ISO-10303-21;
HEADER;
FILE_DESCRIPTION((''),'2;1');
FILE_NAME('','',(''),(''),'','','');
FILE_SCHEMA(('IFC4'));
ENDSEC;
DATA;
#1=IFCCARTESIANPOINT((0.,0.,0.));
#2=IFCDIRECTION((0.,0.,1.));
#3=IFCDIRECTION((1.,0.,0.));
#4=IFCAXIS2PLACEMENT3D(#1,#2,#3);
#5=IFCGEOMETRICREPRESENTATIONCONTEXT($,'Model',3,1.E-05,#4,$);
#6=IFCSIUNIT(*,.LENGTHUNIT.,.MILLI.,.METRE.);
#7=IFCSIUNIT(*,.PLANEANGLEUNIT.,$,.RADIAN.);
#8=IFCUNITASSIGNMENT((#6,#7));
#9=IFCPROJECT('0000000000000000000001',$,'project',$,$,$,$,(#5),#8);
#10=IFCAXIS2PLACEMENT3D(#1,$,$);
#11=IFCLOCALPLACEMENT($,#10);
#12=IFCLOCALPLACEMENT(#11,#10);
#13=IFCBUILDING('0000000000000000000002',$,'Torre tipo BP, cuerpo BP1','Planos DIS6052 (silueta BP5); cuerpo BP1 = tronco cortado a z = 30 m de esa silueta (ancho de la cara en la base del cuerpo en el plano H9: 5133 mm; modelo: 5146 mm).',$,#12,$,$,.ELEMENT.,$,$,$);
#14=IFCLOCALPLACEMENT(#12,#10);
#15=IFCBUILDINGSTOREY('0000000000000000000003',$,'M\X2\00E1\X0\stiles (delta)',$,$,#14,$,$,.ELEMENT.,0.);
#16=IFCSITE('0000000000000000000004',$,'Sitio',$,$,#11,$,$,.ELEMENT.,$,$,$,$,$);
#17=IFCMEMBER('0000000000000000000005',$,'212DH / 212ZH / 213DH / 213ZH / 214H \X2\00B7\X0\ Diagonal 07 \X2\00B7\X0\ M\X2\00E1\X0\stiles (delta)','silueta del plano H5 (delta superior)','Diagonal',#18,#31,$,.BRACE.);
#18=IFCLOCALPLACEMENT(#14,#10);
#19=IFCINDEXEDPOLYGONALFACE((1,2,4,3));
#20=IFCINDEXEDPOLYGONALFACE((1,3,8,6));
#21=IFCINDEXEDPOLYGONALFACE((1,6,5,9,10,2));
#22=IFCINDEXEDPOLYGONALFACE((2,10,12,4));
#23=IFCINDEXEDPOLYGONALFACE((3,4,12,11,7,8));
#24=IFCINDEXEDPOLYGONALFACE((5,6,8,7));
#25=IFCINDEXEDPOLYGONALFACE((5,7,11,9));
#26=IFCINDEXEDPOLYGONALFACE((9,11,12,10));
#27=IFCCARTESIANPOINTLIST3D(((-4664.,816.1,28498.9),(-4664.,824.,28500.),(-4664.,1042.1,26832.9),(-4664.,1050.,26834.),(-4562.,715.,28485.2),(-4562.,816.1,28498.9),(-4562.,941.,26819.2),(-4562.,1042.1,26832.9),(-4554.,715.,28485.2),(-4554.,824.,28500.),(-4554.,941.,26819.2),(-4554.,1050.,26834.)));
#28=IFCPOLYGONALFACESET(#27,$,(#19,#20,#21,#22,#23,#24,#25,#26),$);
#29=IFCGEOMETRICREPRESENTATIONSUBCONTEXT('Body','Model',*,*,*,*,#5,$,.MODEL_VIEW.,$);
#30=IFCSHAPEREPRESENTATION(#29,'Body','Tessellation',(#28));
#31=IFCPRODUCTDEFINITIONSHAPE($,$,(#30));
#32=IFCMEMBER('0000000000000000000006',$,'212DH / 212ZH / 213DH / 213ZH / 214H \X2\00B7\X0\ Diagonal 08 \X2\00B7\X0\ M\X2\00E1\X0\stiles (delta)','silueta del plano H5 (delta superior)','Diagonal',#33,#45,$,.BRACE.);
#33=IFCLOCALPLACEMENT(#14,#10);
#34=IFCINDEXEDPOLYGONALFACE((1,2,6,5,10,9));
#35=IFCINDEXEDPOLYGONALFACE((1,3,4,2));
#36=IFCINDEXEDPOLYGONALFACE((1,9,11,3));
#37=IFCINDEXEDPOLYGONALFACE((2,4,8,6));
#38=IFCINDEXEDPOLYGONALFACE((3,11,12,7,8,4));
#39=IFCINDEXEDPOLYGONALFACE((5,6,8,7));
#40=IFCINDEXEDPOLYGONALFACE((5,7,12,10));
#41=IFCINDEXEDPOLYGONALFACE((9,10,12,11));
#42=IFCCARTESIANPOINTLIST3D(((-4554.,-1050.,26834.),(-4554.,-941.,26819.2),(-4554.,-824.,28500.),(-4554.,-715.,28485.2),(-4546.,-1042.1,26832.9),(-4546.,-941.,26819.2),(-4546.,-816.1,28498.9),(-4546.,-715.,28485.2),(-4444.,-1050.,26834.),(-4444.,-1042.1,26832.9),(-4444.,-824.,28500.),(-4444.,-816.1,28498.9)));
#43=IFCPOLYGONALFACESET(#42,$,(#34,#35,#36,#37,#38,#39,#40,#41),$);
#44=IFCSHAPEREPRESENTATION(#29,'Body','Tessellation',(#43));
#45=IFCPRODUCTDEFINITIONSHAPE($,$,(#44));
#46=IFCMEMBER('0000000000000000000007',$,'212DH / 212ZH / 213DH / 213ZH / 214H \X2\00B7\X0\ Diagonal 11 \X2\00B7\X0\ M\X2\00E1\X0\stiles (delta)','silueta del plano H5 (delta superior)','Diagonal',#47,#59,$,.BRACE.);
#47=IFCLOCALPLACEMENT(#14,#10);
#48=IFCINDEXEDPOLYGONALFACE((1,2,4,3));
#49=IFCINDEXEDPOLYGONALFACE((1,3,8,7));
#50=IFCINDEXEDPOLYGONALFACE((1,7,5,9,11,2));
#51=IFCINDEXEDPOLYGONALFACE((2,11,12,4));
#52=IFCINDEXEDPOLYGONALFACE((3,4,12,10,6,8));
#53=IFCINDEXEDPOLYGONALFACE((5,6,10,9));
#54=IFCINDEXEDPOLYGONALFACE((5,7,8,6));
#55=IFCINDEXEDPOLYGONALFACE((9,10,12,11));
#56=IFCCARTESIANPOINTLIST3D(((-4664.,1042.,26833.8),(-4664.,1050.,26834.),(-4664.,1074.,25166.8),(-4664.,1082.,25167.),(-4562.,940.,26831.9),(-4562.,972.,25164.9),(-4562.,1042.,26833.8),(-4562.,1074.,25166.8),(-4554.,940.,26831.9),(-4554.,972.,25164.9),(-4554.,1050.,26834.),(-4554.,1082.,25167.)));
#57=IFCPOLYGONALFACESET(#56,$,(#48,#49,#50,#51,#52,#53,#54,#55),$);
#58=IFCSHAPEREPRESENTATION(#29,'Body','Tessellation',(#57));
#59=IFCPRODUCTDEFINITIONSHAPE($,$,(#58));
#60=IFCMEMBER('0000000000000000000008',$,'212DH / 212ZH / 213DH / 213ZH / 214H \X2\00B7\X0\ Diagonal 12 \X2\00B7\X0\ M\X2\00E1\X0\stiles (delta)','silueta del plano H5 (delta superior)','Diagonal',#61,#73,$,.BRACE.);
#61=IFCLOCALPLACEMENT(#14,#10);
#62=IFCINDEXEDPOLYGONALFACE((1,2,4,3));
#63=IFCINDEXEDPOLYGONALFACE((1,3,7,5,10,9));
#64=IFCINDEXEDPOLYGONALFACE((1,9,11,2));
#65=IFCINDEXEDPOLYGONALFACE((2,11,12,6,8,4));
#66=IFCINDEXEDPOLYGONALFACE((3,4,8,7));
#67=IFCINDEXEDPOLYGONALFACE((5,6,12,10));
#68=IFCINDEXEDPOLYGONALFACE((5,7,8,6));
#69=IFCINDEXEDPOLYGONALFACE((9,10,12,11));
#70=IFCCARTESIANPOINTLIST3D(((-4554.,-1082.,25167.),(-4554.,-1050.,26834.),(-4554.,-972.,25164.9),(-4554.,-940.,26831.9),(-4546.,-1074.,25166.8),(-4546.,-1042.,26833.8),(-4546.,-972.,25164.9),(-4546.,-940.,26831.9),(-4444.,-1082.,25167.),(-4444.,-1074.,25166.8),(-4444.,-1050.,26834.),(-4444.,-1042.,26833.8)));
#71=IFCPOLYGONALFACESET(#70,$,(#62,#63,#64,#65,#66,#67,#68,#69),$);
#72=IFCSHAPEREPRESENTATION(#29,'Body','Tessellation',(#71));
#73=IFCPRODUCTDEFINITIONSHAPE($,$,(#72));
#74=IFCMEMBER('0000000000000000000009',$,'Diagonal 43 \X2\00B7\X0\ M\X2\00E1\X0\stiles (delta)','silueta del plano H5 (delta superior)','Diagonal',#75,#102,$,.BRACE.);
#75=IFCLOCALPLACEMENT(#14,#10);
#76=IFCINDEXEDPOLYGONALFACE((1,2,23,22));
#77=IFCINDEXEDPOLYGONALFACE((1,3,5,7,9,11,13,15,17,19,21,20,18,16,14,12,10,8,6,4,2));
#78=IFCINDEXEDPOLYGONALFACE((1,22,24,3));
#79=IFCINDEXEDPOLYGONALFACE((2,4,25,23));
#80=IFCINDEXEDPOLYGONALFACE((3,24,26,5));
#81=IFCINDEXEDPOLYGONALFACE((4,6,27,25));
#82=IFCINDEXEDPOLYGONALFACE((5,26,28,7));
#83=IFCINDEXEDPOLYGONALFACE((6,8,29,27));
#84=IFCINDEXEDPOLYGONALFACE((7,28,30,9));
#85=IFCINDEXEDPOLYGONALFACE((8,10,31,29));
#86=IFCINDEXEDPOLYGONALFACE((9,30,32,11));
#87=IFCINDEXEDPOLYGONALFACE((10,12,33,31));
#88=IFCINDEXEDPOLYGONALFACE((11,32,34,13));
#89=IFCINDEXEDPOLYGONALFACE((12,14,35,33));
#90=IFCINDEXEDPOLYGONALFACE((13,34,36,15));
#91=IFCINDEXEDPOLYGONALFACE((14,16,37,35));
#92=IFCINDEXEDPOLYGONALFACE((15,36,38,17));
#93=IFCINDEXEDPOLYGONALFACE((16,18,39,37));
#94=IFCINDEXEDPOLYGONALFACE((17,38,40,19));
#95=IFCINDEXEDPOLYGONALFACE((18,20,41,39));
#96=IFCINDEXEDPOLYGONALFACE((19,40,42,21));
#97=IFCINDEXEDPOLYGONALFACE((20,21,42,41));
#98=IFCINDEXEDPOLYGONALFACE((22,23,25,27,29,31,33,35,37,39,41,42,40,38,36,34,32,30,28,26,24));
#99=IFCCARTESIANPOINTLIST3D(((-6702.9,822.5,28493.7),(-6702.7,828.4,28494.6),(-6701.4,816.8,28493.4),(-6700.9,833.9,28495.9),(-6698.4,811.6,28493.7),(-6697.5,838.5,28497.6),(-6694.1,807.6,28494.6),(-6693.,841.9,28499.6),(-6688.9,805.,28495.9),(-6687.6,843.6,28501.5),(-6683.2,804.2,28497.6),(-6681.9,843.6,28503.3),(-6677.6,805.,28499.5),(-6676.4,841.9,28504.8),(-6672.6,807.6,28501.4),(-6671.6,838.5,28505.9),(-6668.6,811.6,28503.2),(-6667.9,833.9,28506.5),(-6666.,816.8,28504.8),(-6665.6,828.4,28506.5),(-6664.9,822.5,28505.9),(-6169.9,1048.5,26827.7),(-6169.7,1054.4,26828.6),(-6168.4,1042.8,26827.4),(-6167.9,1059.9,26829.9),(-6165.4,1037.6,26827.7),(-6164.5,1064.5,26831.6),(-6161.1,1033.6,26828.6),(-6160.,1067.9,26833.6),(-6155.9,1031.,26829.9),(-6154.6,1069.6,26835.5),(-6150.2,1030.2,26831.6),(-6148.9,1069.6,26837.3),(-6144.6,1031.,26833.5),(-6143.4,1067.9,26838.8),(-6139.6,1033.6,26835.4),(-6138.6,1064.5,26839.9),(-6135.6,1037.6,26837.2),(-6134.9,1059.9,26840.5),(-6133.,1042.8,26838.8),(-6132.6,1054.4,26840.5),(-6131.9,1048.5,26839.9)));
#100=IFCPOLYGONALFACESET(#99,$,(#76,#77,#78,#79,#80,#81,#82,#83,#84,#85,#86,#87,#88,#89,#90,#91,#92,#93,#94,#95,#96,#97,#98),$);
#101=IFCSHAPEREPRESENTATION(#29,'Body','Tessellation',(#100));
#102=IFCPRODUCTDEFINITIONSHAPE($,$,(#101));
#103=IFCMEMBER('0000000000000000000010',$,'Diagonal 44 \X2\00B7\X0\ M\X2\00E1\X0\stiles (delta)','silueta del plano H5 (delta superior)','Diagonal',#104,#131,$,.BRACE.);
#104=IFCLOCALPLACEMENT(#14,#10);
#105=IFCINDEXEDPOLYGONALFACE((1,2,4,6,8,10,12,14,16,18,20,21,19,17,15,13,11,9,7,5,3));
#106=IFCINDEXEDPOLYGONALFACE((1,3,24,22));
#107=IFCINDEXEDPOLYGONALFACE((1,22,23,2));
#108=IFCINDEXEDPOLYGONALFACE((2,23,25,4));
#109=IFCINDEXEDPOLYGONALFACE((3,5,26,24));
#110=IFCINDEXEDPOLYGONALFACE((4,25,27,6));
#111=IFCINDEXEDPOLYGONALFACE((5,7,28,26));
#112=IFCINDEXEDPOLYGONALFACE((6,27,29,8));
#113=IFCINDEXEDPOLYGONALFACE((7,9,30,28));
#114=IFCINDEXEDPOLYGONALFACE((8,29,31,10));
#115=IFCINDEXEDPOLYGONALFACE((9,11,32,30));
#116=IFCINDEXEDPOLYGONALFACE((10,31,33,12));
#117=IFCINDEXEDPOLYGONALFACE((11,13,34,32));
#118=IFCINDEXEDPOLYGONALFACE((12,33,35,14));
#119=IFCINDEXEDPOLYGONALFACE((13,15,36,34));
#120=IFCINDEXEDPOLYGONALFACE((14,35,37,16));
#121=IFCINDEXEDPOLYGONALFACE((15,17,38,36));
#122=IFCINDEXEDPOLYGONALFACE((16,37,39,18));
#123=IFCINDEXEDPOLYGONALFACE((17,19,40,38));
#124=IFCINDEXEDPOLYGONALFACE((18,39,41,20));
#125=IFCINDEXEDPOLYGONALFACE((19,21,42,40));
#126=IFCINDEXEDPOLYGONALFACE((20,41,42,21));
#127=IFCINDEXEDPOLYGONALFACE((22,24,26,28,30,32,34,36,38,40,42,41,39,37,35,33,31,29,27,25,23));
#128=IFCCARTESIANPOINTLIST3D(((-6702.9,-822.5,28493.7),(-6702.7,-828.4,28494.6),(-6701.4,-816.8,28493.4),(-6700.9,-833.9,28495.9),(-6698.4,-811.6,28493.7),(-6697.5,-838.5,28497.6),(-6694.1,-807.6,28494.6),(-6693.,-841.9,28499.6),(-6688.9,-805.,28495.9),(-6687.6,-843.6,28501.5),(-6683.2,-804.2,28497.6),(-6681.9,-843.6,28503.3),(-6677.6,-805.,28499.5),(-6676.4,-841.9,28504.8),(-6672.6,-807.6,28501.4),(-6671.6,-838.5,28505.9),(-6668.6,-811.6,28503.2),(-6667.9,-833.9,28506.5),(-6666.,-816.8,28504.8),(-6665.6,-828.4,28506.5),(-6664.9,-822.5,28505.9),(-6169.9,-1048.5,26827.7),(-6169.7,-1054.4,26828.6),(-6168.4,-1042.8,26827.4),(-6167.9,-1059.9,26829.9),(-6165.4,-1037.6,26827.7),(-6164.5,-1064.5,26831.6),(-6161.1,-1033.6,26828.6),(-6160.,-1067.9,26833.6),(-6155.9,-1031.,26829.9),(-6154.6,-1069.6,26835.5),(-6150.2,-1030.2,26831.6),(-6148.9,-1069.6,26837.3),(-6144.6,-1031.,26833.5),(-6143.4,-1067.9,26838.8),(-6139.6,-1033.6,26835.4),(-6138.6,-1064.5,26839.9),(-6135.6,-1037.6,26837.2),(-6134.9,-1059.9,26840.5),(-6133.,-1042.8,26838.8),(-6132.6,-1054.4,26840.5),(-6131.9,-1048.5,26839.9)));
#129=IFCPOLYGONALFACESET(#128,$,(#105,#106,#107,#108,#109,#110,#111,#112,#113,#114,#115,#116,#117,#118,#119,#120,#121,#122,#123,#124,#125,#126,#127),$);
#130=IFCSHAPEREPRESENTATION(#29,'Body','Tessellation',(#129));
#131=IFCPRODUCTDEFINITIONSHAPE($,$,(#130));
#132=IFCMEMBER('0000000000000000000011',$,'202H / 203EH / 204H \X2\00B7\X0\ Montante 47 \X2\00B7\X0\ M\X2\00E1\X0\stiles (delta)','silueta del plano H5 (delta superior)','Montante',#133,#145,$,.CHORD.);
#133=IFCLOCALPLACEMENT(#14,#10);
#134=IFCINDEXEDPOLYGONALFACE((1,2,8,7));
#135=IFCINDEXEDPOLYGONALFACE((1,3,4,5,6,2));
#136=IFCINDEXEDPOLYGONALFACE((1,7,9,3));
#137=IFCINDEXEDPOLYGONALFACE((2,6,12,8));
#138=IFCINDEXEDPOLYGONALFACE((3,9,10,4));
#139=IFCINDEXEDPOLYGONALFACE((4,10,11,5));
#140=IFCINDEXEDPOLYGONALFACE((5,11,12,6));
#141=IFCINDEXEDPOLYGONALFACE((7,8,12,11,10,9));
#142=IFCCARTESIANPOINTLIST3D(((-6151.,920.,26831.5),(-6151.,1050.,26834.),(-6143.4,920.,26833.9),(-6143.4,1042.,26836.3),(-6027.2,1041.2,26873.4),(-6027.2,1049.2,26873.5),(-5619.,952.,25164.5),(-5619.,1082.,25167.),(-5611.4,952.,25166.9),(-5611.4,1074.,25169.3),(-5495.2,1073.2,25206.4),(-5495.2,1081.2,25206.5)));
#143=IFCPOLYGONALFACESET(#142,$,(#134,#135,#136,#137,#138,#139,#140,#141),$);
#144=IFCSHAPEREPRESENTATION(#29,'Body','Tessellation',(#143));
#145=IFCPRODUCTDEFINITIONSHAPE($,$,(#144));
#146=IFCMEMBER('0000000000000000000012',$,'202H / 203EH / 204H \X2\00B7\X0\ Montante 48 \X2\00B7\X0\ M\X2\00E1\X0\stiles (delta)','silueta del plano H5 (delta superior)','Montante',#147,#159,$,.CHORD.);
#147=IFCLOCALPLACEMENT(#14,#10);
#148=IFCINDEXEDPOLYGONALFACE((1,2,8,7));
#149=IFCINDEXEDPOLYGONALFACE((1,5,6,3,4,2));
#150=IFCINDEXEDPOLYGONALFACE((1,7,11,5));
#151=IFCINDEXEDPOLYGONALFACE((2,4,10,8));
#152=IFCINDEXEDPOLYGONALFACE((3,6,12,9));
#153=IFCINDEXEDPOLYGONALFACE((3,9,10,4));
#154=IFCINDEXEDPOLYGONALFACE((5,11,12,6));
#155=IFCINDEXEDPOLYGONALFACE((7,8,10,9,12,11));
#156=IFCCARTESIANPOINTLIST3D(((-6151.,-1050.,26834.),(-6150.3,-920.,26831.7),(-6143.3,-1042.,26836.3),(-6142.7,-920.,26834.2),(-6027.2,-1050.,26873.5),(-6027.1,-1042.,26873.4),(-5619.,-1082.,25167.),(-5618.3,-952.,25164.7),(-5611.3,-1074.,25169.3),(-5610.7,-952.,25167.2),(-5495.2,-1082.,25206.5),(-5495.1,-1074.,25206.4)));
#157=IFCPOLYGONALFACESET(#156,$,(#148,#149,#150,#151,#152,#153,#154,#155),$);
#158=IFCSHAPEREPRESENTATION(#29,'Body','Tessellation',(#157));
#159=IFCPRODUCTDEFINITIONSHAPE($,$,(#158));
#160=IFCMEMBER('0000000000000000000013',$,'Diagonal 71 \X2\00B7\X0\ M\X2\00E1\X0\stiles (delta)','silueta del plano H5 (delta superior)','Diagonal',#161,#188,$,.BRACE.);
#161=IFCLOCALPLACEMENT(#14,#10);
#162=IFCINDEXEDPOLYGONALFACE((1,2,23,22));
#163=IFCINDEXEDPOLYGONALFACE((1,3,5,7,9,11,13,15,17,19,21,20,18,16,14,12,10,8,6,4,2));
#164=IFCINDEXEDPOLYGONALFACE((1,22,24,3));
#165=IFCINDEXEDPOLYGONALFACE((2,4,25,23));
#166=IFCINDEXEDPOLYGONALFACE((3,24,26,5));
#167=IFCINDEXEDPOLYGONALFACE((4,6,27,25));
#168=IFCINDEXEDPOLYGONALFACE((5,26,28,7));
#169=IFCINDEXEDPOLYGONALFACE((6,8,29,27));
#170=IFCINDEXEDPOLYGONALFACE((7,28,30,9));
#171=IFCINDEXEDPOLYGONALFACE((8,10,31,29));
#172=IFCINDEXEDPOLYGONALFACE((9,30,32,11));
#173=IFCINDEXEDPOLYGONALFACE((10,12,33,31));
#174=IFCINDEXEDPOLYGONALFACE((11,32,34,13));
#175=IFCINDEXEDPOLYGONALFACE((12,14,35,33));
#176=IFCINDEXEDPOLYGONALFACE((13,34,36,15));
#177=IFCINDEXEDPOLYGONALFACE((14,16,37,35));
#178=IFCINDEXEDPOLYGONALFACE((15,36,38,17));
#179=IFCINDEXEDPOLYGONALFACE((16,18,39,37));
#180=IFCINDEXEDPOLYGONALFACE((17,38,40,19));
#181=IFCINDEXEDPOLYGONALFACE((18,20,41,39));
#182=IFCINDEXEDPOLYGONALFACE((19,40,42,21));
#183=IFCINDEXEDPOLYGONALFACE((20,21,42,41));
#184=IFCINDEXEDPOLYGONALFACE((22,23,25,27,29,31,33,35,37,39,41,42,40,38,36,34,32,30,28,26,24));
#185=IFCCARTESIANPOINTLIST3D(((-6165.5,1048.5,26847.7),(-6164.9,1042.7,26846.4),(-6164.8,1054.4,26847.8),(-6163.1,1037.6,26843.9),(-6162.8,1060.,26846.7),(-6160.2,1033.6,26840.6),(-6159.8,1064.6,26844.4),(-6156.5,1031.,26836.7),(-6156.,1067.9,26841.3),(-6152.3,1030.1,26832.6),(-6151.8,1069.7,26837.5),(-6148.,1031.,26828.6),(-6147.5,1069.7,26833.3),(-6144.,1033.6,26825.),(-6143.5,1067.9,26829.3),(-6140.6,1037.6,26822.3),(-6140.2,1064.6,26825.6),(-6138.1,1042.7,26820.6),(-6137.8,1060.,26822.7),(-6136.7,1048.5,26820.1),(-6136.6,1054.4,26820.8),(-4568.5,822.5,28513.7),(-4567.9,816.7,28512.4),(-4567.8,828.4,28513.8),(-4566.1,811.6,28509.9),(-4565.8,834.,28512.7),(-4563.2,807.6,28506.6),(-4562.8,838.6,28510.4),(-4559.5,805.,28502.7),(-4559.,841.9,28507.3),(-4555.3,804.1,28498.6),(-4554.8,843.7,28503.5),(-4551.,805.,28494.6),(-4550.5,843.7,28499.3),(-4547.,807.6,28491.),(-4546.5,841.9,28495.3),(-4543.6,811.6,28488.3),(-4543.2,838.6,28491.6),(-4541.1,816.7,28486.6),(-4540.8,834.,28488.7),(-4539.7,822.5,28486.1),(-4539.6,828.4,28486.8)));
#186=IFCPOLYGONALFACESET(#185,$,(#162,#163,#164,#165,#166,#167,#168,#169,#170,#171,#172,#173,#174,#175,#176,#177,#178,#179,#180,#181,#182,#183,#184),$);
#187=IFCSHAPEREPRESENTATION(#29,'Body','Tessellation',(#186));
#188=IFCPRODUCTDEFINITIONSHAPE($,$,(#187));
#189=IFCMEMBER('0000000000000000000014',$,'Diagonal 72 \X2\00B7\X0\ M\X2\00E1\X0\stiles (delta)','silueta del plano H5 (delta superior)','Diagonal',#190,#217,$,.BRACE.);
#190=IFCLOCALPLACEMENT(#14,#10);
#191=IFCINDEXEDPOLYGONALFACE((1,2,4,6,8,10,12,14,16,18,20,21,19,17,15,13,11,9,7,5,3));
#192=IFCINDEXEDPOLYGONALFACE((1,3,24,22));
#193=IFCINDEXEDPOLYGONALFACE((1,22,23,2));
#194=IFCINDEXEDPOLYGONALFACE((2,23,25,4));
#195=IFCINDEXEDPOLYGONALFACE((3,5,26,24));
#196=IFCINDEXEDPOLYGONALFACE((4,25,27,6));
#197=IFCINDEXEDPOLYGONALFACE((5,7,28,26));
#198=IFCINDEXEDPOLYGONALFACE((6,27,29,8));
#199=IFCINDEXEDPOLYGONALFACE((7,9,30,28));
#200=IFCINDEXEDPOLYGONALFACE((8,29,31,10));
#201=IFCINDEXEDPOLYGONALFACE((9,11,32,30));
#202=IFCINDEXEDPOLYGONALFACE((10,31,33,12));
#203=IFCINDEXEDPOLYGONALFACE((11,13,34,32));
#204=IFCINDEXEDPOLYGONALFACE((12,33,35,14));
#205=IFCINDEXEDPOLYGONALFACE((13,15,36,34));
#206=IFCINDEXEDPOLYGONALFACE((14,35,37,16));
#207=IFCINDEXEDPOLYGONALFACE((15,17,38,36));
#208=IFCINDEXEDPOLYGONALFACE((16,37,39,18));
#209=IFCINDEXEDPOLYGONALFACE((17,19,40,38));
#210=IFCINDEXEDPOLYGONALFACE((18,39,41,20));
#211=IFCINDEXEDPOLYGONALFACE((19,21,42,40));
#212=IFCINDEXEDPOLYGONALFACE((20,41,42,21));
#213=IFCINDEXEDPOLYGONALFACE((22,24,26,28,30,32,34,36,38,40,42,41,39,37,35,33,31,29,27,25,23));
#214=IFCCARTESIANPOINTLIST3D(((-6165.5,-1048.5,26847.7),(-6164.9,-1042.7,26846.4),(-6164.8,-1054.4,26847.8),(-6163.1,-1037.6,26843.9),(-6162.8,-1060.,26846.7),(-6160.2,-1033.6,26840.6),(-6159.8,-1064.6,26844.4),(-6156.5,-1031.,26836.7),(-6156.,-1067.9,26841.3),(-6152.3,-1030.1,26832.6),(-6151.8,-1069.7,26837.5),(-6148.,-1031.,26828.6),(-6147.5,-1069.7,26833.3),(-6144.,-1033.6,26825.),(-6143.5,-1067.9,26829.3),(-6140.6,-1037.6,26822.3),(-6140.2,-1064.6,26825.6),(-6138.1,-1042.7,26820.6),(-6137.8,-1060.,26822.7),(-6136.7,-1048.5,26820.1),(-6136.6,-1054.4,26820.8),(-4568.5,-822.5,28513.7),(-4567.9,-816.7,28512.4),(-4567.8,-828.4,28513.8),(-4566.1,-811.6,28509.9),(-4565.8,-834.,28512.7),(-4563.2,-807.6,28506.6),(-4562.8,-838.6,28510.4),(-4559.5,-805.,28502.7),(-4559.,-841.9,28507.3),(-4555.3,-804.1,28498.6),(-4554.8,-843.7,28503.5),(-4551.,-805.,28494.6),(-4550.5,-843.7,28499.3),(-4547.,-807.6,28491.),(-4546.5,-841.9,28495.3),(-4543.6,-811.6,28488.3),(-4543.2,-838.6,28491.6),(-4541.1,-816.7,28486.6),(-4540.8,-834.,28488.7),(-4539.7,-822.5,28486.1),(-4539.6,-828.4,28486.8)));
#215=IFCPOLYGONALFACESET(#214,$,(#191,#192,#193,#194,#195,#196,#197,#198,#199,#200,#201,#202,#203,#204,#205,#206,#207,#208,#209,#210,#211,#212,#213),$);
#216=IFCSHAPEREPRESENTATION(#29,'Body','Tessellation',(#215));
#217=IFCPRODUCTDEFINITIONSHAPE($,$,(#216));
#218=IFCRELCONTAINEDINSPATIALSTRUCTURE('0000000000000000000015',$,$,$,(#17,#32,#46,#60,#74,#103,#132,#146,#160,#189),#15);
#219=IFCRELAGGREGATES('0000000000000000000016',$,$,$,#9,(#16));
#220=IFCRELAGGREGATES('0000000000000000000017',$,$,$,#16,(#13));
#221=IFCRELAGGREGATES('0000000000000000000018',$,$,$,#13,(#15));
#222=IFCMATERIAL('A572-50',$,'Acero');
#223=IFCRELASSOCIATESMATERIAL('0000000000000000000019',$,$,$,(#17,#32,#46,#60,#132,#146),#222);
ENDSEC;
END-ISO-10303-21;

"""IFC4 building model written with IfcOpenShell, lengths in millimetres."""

from ifc_helpers import new_model, si_unit, frame, frame_2d, origin, origin_with_axes, place, context, subcontext, project, spatial, circle, l_section, extrude, material, element, save


model = new_model("IFC4")

# Units and contexts
model_context = context("Model", 3, precision=1e-05, world=origin_with_axes())
body_context = subcontext(model_context, "Body", "Model", "MODEL_VIEW")
ifc_project = project(units=[si_unit("LENGTHUNIT", "METRE", prefix="MILLI"), si_unit("PLANEANGLEUNIT", "RADIAN")], contexts=[model_context])

# Site, building, storey
site_placement = place(None, origin())
site = spatial("IfcSite", under=ifc_project, at=site_placement, Name="Sitio", CompositionType="ELEMENT")
building_placement = place(site_placement, origin())
building = spatial("IfcBuilding", under=site, at=building_placement, Name="Torre tipo BP, cuerpo BP1", Description="Planos DIS6052 (silueta BP5); cuerpo BP1 = tronco cortado a z = 30 m de esa silueta (ancho de la cara en la base del cuerpo en el plano H9: 5133 mm; modelo: 5146 mm).", CompositionType="ELEMENT")
storey_placement = place(building_placement, origin())
storey = spatial("IfcBuildingStorey", under=building, at=storey_placement, Name="Mástiles (delta)", CompositionType="ELEMENT", Elevation=0.0)

# Members
ifc_material = material(Name="A572-50", Category="Acero")
for number, where, z_axis, x_axis, name in (
    (1, (-4554.0, 824.0, 28500.0), (0.0, 0.134423, -0.990924), (0.0, -0.990924, -0.134423), "212DH / 212ZH / 213DH / 213ZH / 214H · Diagonal 07 · Mástiles (delta)"),
    (2, (-4554.0, -824.0, 28500.0), (0.0, -0.134423, -0.990924), (0.0, 0.990924, -0.134423), "212DH / 212ZH / 213DH / 213ZH / 214H · Diagonal 08 · Mástiles (delta)"),
):
    element("IfcMember", number, at=place(storey_placement, frame(where, z_axis=z_axis, x_axis=x_axis)), inside=storey, material=ifc_material, Name=name, Description="silueta del plano H5 (delta superior)", ObjectType="Diagonal", PredefinedType="BRACE", context=body_context, shape_type="SweptSolid", body=[
        extrude(l_section(Depth=110.0, Width=110.0, Thickness=8.0, at=frame_2d((55.0, 55.0))), None, (0.0, 0.0, 1.0), 1681.3),
    ])
for number, where, z_axis, x_axis, name in (
    (3, (-4554.0, 1050.0, 26834.0), (0.0, 0.019193, -0.999816), (0.0, -0.999816, -0.019193), "212DH / 212ZH / 213DH / 213ZH / 214H · Diagonal 11 · Mástiles (delta)"),
    (4, (-4554.0, -1050.0, 26834.0), (0.0, -0.019193, -0.999816), (0.0, 0.999816, -0.019193), "212DH / 212ZH / 213DH / 213ZH / 214H · Diagonal 12 · Mástiles (delta)"),
):
    element("IfcMember", number, at=place(storey_placement, frame(where, z_axis=z_axis, x_axis=x_axis)), inside=storey, material=ifc_material, Name=name, Description="silueta del plano H5 (delta superior)", ObjectType="Diagonal", PredefinedType="BRACE", context=body_context, shape_type="SweptSolid", body=[
        extrude(l_section(Depth=110.0, Width=110.0, Thickness=8.0, at=frame_2d((55.0, 55.0))), None, (0.0, 0.0, 1.0), 1667.3),
    ])
for number, where, z_axis, x_axis, name in (
    (5, (-6684.0, 824.0, 28500.0), (0.302202, 0.128138, -0.944592), (0.039045, -0.991756, -0.122044), "Diagonal 43 · Mástiles (delta)"),
    (6, (-6684.0, -824.0, 28500.0), (0.302202, -0.128138, -0.944592), (0.039045, 0.991756, -0.122044), "Diagonal 44 · Mástiles (delta)"),
):
    element("IfcMember", number, at=place(storey_placement, frame(where, z_axis=z_axis, x_axis=x_axis)), inside=storey, Name=name, Description="silueta del plano H5 (delta superior)", ObjectType="Diagonal", PredefinedType="BRACE", context=body_context, shape_type="SweptSolid", body=[
        extrude(circle(Radius=20.0), None, (0.0, 0.0, 1.0), 1763.7),
    ])
for number, where, z_axis, x_axis, name in (
    (7, (-6151.0, 1050.0, 26834.0), (0.303978, 0.018284, -0.952503), (0.952679, -0.005834, 0.303922), "202H / 203EH / 204H · Montante 47 · Mástiles (delta)"),
    (8, (-6151.0, -1050.0, 26834.0), (0.303978, -0.018284, -0.952503), (0.005559, 0.999833, -0.017419), "202H / 203EH / 204H · Montante 48 · Mástiles (delta)"),
):
    element("IfcMember", number, at=place(storey_placement, frame(where, z_axis=z_axis, x_axis=x_axis)), inside=storey, material=ifc_material, Name=name, Description="silueta del plano H5 (delta superior)", ObjectType="Montante", PredefinedType="CHORD", context=body_context, shape_type="SweptSolid", body=[
        extrude(l_section(Depth=130.0, Width=130.0, Thickness=8.0, at=frame_2d((65.0, 65.0))), None, (0.0, 0.0, 1.0), 1750.1),
    ])
for number, where, z_axis, x_axis, name in (
    (9, (-4554.0, 824.0, 28500.0), (-0.688705, 0.097462, -0.718461), (-0.067444, -0.995239, -0.070358), "Diagonal 71 · Mástiles (delta)"),
    (10, (-4554.0, -824.0, 28500.0), (-0.688705, -0.097462, -0.718461), (-0.067444, 0.995239, -0.070358), "Diagonal 72 · Mástiles (delta)"),
):
    element("IfcMember", number, at=place(storey_placement, frame(where, z_axis=z_axis, x_axis=x_axis)), inside=storey, Name=name, Description="silueta del plano H5 (delta superior)", ObjectType="Diagonal", PredefinedType="BRACE", context=body_context, shape_type="SweptSolid", body=[
        extrude(circle(Radius=20.0), None, (0.0, 0.0, 1.0), 2318.8),
    ])

save(model, "model.ifc")
